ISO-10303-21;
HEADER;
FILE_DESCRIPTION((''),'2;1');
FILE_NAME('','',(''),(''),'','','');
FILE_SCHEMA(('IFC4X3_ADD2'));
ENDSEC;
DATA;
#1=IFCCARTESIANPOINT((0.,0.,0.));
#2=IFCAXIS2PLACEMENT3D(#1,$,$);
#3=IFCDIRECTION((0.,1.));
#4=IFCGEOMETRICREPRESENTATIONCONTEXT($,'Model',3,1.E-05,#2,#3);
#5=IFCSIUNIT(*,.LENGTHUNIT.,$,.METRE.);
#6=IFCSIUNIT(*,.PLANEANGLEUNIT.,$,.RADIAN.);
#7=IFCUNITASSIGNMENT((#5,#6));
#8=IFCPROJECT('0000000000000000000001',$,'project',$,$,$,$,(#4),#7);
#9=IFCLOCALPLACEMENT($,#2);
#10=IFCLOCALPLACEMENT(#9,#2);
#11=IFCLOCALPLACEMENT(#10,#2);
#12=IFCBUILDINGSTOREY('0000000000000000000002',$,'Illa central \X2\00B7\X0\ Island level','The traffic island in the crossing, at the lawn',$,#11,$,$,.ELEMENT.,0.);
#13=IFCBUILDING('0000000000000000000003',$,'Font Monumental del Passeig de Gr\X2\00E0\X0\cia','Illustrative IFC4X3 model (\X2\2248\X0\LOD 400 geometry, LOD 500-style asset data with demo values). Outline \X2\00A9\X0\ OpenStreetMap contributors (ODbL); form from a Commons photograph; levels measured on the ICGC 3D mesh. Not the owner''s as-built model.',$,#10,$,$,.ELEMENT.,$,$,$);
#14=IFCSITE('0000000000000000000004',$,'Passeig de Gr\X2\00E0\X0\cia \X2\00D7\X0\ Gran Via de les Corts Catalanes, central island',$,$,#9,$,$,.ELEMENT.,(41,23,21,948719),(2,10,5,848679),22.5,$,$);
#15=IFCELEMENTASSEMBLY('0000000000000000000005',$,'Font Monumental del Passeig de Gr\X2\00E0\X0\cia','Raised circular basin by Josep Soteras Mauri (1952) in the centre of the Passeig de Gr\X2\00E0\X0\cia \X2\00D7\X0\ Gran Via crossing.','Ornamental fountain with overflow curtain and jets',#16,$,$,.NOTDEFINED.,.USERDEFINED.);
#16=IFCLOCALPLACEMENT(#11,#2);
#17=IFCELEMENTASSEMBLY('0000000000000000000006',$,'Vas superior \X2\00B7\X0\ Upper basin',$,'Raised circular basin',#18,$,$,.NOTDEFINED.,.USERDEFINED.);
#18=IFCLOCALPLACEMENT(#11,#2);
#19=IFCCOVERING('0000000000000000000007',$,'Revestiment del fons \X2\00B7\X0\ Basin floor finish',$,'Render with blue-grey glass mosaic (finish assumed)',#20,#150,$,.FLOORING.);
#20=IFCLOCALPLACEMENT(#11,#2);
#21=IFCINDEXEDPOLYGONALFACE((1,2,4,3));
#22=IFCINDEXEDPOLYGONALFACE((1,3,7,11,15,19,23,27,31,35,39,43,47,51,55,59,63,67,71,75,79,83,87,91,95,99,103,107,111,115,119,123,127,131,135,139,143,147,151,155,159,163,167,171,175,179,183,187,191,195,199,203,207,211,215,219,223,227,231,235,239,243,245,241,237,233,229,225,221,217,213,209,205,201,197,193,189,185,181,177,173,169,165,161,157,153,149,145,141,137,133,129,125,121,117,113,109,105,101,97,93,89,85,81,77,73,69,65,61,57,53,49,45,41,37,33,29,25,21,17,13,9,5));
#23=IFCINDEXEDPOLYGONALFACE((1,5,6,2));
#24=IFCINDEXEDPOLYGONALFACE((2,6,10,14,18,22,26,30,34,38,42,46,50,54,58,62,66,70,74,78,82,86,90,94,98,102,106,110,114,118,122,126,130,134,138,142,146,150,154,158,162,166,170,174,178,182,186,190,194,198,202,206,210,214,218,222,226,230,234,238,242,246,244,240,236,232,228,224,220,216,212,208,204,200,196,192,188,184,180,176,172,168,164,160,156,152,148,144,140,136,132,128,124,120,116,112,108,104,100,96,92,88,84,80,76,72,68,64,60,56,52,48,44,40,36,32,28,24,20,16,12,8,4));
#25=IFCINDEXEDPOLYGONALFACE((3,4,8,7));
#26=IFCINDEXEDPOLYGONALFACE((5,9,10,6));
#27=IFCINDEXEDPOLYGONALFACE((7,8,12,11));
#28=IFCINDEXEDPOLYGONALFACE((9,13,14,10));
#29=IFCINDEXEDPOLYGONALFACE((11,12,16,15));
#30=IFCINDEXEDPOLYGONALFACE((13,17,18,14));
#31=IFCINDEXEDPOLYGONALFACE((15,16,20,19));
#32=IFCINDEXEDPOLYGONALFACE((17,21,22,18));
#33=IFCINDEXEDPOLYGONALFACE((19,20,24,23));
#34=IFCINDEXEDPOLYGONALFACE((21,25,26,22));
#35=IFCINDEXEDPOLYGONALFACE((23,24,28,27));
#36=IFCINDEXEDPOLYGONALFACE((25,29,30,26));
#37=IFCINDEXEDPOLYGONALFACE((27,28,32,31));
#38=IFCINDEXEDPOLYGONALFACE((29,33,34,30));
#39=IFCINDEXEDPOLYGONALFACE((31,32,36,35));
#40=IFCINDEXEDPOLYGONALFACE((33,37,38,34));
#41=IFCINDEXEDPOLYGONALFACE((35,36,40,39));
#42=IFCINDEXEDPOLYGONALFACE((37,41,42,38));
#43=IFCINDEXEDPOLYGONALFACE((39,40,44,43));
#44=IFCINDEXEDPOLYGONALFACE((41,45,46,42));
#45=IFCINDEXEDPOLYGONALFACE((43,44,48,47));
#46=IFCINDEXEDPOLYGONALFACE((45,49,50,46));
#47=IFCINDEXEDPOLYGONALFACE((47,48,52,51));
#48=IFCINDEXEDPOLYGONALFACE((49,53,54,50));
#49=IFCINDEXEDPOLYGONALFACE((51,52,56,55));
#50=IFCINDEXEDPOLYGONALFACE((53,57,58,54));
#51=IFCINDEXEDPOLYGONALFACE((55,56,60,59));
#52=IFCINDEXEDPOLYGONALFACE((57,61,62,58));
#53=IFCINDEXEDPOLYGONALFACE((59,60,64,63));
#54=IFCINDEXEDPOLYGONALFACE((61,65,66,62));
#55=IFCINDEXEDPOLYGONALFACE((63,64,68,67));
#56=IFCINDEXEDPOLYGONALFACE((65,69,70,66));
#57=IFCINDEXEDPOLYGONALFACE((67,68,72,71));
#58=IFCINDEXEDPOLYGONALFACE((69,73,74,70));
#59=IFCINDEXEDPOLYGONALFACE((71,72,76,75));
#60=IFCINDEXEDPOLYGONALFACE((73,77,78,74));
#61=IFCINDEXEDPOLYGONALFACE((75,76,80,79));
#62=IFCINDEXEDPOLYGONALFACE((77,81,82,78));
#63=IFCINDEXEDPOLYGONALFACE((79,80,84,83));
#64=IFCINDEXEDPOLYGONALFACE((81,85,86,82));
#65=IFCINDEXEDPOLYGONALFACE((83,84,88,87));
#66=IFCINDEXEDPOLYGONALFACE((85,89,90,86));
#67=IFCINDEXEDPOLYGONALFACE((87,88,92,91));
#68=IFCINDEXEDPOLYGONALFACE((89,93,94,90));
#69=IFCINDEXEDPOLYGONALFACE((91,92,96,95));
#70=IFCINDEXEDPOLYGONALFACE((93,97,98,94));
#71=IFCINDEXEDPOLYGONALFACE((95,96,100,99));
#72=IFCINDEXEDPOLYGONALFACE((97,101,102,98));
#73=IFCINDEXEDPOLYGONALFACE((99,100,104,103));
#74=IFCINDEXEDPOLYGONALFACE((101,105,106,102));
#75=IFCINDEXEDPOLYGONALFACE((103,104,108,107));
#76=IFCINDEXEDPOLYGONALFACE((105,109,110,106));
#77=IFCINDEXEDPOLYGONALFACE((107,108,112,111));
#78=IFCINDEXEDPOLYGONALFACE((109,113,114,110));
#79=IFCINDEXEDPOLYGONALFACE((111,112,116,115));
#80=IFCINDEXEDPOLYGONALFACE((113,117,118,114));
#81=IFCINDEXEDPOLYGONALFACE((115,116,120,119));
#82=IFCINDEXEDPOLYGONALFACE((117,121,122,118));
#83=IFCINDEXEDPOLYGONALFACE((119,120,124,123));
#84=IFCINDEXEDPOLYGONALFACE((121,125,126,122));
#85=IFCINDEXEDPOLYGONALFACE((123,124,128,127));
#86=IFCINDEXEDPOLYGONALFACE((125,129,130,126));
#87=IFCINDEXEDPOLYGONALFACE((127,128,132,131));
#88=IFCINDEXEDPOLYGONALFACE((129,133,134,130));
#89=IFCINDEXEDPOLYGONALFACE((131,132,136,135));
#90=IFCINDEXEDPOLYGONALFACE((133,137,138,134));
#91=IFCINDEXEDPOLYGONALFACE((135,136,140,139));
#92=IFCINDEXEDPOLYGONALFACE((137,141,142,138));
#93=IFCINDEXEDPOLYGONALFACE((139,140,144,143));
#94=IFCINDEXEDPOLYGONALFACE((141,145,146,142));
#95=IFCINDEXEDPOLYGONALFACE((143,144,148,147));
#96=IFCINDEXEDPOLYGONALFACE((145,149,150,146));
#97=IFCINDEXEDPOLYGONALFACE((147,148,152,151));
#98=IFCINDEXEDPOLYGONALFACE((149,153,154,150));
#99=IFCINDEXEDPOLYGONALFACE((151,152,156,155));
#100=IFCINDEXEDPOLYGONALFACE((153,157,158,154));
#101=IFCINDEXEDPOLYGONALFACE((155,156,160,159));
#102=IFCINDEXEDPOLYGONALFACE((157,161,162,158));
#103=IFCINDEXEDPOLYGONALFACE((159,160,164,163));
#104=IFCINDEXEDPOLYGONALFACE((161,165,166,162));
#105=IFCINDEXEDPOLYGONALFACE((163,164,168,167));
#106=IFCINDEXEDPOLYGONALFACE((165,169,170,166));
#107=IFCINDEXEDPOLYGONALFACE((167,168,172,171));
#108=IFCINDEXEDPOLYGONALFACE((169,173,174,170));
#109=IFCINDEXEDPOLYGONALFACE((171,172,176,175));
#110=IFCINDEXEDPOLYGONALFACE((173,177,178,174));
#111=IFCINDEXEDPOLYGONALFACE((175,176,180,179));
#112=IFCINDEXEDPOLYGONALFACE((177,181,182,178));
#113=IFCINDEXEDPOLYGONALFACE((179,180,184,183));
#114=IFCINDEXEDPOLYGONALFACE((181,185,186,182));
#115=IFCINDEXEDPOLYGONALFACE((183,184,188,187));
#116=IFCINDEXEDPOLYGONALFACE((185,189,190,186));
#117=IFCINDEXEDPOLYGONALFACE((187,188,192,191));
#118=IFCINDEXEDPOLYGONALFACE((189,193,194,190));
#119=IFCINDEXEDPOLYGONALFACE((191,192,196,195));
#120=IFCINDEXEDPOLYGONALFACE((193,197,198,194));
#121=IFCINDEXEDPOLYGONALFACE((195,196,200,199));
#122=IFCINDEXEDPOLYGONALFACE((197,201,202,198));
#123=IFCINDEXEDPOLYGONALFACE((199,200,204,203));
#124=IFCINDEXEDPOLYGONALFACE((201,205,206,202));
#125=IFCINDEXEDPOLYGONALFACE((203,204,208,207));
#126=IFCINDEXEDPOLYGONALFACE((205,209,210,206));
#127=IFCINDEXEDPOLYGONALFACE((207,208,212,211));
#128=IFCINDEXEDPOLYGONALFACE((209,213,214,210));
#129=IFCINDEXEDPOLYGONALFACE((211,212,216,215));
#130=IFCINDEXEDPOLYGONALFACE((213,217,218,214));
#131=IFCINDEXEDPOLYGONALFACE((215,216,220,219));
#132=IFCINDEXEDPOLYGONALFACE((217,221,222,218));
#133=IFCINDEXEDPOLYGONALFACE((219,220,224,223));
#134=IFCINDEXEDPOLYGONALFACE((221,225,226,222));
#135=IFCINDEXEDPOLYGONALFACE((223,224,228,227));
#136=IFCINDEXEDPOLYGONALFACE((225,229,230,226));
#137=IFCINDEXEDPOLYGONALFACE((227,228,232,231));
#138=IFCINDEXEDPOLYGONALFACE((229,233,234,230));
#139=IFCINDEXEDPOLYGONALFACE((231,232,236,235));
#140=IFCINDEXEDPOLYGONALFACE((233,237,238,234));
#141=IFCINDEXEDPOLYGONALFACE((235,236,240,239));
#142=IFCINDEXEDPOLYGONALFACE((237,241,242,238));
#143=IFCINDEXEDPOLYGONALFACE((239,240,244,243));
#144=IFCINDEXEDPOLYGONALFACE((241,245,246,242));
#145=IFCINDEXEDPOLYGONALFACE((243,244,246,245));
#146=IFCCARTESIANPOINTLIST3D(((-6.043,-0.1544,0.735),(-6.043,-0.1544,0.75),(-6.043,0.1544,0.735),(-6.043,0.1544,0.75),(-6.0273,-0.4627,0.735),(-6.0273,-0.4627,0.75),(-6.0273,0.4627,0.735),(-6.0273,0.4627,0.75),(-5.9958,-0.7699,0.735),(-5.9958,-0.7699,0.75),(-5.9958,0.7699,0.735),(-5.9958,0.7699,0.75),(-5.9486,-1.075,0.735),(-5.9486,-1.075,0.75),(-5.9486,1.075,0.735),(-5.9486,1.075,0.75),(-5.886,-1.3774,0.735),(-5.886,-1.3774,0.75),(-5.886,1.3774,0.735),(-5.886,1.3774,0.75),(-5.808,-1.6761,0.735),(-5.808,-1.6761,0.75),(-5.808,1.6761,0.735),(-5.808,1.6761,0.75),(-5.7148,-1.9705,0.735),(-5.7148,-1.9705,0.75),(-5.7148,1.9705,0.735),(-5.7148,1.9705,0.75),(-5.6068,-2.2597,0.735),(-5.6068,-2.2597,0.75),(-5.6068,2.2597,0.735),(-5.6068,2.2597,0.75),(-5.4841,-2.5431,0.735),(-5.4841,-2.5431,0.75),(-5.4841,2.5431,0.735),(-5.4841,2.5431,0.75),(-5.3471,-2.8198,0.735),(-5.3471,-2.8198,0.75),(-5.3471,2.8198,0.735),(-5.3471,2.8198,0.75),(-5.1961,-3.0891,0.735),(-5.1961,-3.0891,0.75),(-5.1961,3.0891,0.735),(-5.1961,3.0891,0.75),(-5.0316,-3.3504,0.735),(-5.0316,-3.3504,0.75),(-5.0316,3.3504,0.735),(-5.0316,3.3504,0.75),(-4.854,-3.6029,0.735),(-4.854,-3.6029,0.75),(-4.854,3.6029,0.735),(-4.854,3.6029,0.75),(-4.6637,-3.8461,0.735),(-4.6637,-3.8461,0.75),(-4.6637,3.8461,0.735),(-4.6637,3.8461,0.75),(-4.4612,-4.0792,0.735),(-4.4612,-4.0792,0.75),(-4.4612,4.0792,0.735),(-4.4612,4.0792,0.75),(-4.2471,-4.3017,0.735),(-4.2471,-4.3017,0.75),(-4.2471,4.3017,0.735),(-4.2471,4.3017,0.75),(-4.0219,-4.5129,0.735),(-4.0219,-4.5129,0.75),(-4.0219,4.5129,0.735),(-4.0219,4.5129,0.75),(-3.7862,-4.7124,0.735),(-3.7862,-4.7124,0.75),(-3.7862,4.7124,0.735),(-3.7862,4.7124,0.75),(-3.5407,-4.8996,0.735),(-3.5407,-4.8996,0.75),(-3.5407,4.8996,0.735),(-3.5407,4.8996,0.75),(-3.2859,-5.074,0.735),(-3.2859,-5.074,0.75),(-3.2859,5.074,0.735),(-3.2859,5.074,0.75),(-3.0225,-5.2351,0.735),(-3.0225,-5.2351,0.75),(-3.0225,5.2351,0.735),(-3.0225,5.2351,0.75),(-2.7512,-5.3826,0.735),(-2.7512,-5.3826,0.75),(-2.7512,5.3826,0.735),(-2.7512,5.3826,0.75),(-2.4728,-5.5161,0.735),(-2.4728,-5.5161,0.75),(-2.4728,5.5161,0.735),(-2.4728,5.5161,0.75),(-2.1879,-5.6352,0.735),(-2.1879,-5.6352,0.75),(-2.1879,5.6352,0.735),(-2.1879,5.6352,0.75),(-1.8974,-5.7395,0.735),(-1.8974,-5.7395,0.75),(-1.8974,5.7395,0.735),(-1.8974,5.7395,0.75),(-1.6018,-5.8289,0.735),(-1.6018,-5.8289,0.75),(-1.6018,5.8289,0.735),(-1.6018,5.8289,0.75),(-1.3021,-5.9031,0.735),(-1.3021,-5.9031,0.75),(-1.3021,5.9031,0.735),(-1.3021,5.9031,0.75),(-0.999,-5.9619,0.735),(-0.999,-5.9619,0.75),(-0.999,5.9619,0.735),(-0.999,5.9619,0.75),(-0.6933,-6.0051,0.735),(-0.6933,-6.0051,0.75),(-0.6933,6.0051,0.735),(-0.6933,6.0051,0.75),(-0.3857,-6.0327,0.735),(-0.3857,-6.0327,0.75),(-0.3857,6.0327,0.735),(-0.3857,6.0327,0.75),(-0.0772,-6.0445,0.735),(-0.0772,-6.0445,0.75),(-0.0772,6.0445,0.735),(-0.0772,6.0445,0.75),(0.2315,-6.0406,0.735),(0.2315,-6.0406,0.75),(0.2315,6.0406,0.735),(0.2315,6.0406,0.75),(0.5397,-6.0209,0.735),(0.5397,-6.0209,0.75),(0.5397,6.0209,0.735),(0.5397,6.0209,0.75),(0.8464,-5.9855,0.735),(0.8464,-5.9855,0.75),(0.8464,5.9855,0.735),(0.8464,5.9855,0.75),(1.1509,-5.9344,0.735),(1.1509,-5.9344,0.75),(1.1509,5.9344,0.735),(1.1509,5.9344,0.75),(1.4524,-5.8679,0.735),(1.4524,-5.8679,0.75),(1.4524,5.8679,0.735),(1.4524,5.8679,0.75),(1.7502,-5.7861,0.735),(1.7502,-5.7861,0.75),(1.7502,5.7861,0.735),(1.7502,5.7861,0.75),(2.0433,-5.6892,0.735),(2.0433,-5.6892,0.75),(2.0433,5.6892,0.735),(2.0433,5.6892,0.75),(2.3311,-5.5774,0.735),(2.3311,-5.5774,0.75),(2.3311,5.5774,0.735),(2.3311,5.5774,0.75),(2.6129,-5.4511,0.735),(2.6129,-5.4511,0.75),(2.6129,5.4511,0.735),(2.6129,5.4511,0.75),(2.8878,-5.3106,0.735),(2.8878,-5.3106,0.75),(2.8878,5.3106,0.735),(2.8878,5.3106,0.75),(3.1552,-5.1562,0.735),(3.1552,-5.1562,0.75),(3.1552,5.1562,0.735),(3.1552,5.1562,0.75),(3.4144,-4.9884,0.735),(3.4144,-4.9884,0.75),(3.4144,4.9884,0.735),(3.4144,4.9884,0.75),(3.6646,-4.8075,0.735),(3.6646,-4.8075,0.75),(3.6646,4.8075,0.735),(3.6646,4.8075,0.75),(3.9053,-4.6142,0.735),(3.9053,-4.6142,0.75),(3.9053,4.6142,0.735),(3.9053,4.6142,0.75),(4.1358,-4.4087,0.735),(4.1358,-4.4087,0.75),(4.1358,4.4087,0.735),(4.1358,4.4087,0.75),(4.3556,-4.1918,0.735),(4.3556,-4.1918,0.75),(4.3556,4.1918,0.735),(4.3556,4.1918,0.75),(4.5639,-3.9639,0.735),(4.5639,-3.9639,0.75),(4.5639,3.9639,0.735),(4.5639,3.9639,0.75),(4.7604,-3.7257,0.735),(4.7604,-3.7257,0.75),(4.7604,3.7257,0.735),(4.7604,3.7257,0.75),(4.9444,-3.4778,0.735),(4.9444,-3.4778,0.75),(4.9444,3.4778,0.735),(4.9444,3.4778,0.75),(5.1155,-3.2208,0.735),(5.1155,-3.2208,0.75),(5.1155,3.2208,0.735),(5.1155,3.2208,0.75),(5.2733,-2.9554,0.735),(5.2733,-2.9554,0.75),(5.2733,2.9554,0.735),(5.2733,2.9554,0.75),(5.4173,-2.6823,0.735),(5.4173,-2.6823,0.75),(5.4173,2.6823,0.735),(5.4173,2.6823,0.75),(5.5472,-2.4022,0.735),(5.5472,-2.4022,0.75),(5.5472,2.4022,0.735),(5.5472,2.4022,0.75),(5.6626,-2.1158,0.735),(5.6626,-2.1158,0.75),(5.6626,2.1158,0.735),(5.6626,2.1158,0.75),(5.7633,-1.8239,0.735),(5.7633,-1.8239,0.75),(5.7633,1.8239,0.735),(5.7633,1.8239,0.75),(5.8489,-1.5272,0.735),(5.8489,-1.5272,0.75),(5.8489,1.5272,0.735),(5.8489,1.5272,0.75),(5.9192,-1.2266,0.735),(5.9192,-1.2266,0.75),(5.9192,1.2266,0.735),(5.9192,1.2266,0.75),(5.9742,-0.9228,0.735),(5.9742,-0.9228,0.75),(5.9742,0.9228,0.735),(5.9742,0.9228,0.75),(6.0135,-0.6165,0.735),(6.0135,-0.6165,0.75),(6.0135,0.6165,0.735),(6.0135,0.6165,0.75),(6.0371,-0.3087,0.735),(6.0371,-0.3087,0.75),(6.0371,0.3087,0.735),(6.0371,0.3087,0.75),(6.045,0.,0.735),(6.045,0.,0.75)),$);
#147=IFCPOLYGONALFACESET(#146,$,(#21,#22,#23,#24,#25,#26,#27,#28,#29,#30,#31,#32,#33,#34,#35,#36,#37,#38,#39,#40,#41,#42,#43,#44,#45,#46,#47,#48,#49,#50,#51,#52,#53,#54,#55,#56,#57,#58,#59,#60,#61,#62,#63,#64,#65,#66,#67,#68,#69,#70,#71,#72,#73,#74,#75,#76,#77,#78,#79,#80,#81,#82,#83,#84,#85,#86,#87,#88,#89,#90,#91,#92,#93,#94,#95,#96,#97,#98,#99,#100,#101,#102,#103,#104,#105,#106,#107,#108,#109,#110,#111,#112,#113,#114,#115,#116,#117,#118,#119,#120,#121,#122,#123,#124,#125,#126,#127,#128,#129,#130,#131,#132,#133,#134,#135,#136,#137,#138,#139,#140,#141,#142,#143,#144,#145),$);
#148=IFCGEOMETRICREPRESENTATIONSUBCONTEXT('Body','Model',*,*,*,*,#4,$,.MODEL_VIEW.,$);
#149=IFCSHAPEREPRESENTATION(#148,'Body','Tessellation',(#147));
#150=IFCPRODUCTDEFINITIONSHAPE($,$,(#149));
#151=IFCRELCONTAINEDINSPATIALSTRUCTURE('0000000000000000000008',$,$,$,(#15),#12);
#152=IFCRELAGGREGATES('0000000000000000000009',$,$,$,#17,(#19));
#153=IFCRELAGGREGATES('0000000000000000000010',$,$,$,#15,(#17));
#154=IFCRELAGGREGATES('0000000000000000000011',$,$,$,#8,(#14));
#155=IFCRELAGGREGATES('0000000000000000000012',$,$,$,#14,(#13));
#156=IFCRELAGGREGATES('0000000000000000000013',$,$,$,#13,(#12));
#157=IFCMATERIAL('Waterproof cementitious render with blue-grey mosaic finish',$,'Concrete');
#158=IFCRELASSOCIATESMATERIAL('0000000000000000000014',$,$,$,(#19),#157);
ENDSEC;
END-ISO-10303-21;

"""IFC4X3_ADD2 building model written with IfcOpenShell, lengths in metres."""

from ifc_helpers import new_model, si_unit, direction, frame, origin, origin_2d_with_axis, place, context, subcontext, project, spatial, circle, extrude, material, element, aggregate, save


model = new_model("IFC4X3_ADD2")

# Units and contexts
model_context = context("Model", 3, precision=1e-05, world=origin(), true_north=direction((0.0, 1.0)))
body_context = subcontext(model_context, "Body", "Model", "MODEL_VIEW")
ifc_project = project(units=[si_unit("LENGTHUNIT", "METRE"), si_unit("PLANEANGLEUNIT", "RADIAN")], contexts=[model_context])

# Site, building, storey
site_placement = place(None, origin())
site = spatial("IfcSite", under=ifc_project, at=site_placement, Name="Passeig de Gràcia × Gran Via de les Corts Catalanes, central island", CompositionType="ELEMENT", RefLatitude=(41, 23, 21, 948719), RefLongitude=(2, 10, 5, 848679), RefElevation=22.5)
building_placement = place(site_placement, origin())
building = spatial("IfcBuilding", under=site, at=building_placement, Name="Font Monumental del Passeig de Gràcia", Description="Illustrative IFC4X3 model (≈LOD 400 geometry, LOD 500-style asset data with demo values). Outline © OpenStreetMap contributors (ODbL); form from a Commons photograph; levels measured on the ICGC 3D mesh. Not the owner's as-built model.", CompositionType="ELEMENT")
storey_placement = place(building_placement, origin())
storey = spatial("IfcBuildingStorey", under=building, at=storey_placement, Name="Illa central · Island level", Description="The traffic island in the crossing, at the lawn", CompositionType="ELEMENT", Elevation=0.0)

# Element assemblies, covering
assembly_1_placement = place(building_placement, origin())
assembly_1 = element("IfcElementAssembly", 1, at=assembly_1_placement, inside=storey, Name="Font Monumental del Passeig de Gràcia", Description="Raised circular basin by Josep Soteras Mauri (1952) in the centre of the Passeig de Gràcia × Gran Via crossing.", ObjectType="Ornamental fountain with overflow curtain and jets", AssemblyPlace="NOTDEFINED", PredefinedType="USERDEFINED")
assembly_2_placement = place(building_placement, origin())
assembly_2 = element("IfcElementAssembly", 2, at=assembly_2_placement, Name="Vas superior · Upper basin", ObjectType="Raised circular basin", AssemblyPlace="NOTDEFINED", PredefinedType="USERDEFINED")
ifc_material_1 = material(Name="Waterproof cementitious render with blue-grey mosaic finish", Category="Concrete")
covering_1_placement = place(building_placement, origin())
covering_1 = element("IfcCovering", 3, at=covering_1_placement, material=ifc_material_1, Name="Revestiment del fons · Basin floor finish", ObjectType="Render with blue-grey glass mosaic (finish assumed)", PredefinedType="FLOORING", context=body_context, shape_type="SweptSolid", body=[
    extrude(circle(Radius=6.045, at=origin_2d_with_axis()), frame((0.0, 0.0, 0.735)), (0.0, 0.0, 1.0), 0.015),
])
aggregate(assembly_2, [covering_1])
aggregate(assembly_1, [assembly_2])

save(model, "model.ifc")
